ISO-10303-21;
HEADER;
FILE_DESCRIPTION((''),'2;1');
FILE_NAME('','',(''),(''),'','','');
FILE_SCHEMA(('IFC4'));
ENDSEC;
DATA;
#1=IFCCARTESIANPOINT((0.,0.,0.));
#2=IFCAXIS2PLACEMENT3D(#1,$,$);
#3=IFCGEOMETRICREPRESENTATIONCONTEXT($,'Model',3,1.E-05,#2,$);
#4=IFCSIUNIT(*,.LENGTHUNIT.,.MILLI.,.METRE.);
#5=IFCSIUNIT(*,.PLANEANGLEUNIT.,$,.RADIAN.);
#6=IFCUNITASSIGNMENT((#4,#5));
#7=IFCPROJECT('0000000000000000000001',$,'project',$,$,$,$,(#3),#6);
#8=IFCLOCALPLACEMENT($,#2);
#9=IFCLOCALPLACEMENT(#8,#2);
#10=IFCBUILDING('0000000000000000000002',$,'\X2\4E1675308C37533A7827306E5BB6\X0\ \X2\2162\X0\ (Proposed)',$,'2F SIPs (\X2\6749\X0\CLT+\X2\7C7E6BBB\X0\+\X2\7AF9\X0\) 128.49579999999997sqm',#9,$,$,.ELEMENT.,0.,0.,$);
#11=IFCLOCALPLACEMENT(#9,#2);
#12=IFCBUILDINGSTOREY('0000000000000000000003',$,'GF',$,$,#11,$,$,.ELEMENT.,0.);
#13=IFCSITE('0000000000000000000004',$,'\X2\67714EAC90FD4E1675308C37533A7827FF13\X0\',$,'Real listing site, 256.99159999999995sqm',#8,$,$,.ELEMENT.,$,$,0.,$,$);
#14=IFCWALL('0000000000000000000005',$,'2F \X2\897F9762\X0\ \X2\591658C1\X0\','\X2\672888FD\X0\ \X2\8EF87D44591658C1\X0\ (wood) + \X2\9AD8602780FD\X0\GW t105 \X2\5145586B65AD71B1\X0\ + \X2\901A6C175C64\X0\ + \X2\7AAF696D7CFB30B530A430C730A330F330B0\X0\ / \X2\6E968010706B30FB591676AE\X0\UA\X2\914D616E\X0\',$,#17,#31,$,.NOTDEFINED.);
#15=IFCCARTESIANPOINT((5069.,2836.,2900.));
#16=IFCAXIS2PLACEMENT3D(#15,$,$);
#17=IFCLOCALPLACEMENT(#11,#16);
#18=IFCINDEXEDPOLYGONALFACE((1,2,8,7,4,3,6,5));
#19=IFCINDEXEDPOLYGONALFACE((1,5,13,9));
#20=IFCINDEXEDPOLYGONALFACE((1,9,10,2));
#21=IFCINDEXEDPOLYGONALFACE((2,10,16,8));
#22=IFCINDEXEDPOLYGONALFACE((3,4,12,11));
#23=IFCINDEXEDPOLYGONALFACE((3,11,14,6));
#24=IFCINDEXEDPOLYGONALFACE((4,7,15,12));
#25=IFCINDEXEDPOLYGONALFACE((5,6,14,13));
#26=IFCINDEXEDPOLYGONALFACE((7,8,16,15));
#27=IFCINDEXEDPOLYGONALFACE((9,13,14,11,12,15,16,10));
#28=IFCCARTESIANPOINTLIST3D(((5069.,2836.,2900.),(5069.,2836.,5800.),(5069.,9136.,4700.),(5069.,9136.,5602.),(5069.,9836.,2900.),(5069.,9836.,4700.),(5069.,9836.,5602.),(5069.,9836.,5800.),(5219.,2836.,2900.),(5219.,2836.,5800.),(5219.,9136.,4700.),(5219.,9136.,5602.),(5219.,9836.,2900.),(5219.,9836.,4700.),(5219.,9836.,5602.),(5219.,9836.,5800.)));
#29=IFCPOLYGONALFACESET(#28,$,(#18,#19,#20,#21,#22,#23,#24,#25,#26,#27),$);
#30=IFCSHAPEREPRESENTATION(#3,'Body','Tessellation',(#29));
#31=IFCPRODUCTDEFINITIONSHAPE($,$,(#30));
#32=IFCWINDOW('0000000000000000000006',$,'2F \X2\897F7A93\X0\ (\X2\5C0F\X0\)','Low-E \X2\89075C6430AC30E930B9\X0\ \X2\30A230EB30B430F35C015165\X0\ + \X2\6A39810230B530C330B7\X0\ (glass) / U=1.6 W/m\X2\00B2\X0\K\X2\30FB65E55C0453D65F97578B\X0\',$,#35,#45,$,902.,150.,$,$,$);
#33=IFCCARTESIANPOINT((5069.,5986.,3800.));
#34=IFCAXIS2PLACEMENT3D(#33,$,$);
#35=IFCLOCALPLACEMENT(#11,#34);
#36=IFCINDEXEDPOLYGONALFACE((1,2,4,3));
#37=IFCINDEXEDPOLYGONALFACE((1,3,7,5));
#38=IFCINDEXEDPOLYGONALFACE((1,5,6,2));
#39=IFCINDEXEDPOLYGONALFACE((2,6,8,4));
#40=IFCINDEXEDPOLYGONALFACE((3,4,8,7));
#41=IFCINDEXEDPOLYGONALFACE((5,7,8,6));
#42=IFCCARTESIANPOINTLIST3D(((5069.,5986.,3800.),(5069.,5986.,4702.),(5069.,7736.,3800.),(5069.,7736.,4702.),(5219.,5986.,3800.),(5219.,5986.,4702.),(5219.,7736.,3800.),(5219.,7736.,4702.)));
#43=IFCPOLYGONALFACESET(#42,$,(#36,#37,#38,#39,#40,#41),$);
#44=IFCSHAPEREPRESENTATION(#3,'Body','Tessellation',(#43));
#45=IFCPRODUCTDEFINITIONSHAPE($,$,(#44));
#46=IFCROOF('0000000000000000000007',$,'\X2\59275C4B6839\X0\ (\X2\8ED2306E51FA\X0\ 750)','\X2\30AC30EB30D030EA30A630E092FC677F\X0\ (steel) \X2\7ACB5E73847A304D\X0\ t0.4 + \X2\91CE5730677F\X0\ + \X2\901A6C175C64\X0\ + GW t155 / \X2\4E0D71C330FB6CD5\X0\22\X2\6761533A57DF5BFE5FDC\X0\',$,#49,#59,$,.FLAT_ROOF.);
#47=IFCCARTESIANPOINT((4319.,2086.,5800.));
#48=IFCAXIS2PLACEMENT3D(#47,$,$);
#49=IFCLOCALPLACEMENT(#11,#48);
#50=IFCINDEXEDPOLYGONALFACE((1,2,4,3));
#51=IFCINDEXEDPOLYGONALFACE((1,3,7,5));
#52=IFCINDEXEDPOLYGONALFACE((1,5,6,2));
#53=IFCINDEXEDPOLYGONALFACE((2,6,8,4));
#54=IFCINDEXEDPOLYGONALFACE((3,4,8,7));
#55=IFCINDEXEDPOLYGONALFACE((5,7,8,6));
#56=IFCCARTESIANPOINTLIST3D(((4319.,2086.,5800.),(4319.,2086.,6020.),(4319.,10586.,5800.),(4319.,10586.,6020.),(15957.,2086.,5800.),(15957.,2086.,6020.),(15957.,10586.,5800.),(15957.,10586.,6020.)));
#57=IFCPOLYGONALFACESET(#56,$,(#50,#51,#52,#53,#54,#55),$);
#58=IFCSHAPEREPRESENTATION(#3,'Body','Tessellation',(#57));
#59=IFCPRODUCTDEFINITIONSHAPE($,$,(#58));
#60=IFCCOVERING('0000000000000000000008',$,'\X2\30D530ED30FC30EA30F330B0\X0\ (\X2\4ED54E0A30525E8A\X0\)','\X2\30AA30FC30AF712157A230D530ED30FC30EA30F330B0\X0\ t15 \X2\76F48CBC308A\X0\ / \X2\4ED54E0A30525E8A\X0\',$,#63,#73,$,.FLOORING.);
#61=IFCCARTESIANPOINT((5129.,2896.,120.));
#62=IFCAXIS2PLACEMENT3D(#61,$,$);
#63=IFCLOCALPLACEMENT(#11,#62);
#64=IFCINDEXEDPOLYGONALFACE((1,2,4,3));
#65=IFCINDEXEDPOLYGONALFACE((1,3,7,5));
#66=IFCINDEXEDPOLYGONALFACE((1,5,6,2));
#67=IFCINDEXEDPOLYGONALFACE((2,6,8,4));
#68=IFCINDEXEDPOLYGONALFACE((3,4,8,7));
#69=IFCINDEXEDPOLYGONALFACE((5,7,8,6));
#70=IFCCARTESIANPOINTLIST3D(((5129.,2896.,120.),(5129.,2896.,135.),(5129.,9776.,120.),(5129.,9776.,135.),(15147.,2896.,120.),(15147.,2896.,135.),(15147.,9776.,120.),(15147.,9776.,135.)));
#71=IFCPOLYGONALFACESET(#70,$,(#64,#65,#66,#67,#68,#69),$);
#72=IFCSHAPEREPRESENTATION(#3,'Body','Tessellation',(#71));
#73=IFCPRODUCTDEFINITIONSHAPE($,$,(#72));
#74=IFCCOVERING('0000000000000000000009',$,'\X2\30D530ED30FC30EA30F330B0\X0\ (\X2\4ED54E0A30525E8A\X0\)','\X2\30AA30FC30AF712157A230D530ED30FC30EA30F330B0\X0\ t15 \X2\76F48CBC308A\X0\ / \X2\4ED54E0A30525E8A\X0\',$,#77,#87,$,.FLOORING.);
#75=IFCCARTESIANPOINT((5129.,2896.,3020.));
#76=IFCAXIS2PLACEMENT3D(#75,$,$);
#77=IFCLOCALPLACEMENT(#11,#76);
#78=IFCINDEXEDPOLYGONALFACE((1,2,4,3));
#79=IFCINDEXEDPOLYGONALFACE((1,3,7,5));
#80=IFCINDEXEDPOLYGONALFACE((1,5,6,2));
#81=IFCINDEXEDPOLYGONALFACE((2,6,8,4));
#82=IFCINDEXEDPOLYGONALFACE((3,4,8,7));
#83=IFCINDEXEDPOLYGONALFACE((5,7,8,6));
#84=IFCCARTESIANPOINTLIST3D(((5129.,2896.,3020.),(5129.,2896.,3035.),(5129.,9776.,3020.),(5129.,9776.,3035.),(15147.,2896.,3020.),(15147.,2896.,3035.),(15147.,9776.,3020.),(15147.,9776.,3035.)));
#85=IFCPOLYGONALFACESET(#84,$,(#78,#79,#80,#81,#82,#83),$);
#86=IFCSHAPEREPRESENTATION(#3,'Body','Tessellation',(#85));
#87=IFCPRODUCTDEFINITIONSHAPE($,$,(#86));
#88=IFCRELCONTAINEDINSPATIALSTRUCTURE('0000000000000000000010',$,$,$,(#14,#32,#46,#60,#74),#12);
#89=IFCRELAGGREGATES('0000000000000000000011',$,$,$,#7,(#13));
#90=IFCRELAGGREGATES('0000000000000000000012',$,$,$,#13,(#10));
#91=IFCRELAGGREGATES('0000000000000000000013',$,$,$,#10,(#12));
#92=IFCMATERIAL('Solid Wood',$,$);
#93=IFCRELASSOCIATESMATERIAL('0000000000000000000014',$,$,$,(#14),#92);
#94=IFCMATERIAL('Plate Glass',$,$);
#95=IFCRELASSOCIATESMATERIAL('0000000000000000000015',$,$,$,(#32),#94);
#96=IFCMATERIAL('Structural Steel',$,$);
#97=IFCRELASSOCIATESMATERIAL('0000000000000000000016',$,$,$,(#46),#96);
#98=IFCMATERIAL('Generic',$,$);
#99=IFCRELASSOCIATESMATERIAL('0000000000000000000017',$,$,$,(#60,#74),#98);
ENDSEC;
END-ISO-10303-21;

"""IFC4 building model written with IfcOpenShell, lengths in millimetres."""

from ifc_helpers import new_model, si_unit, frame, frame_2d, origin, place, context, project, spatial, rectangle, extrude, material, element, fill, save


model = new_model("IFC4")

# Units and contexts
model_context = context("Model", 3, precision=1e-05, world=origin())
ifc_project = project(units=[si_unit("LENGTHUNIT", "METRE", prefix="MILLI"), si_unit("PLANEANGLEUNIT", "RADIAN")], contexts=[model_context])

# Site, building, storey
site_placement = place(None, origin())
site = spatial("IfcSite", under=ifc_project, at=site_placement, Name="東京都世田谷区砧３", ObjectType="Real listing site, 256.99159999999995sqm", CompositionType="ELEMENT", RefElevation=0.0)
building_placement = place(site_placement, origin())
building = spatial("IfcBuilding", under=site, at=building_placement, Name="世田谷区砧の家 Ⅲ (Proposed)", ObjectType="2F SIPs (杉CLT+籾殻+竹) 128.49579999999997sqm", CompositionType="ELEMENT", ElevationOfRefHeight=0.0, ElevationOfTerrain=0.0)
storey_placement = place(building_placement, origin())
storey = spatial("IfcBuildingStorey", under=building, at=storey_placement, Name="GF", CompositionType="ELEMENT", Elevation=0.0)

# Shared definitions
ifc_material_1 = material(Name="Solid Wood")

# Shared definitions
ifc_material_2 = material(Name="Plate Glass")

# Wall, opening, window
wall_1_placement = place(storey_placement, frame((5069.0, 2836.0, 2900.0)))
wall_1 = element("IfcWall", 1, at=wall_1_placement, inside=storey, material=ifc_material_1, Name="2F 西面 外壁", Description="木製 軸組外壁 (wood) + 高性能GW t105 充填断熱 + 通気層 + 窯業系サイディング / 準耐火・外皮UA配慮", PredefinedType="NOTDEFINED", context=model_context, shape_type="SweptSolid", body=[
    extrude(rectangle(XDim=150.0, YDim=7000.0, at=frame_2d((75.0, 3500.0))), frame((5069.0, 2836.0, 2900.0)), (0.0, 0.0, 1.0), 2900.0),
])
opening_1_placement = place(storey_placement, frame((5069.0, 5986.0, 3800.0)))
opening_1 = element("IfcOpeningElement", 2, at=opening_1_placement, cuts=wall_1, PredefinedType="NOTDEFINED", context=model_context, shape_type="SweptSolid", body=[
    extrude(rectangle(XDim=150.0, YDim=1750.0, at=frame_2d((75.0, 875.0))), frame((5069.0, 5986.0, 3800.0)), (0.0, 0.0, 1.0), 902.0),
])
window_1_placement = place(storey_placement, frame((5069.0, 5986.0, 3800.0)))
window_1 = element("IfcWindow", 3, at=window_1_placement, inside=storey, material=ifc_material_2, Name="2F 西窓 (小)", Description="Low-E 複層ガラス アルゴン封入 + 樹脂サッシ (glass) / U=1.6 W/m²K・日射取得型", OverallHeight=902.0, OverallWidth=150.0, context=model_context, shape_type="SweptSolid", body=[
    extrude(rectangle(XDim=150.0, YDim=1750.0, at=frame_2d((75.0, 875.0))), frame((5069.0, 5986.0, 3800.0)), (0.0, 0.0, 1.0), 902.0),
])
fill(opening_1, window_1)

# Roof
ifc_material_3 = material(Name="Structural Steel")
roof_placement = place(storey_placement, frame((4319.0, 2086.0, 5800.0)))
element("IfcRoof", 4, at=roof_placement, inside=storey, material=ifc_material_3, Name="大屋根 (軒の出 750)", Description="ガルバリウム鋼板 (steel) 立平葺き t0.4 + 野地板 + 通気層 + GW t155 / 不燃・法22条区域対応", PredefinedType="FLAT_ROOF", context=model_context, shape_type="SweptSolid", body=[
    extrude(rectangle(XDim=11638.0, YDim=8500.0, at=frame_2d((5819.0, 4250.0))), frame((4319.0, 2086.0, 5800.0)), (0.0, 0.0, 1.0), 220.0),
])

# Coverings
ifc_material_4 = material(Name="Generic")
covering_1_placement = place(storey_placement, frame((5129.0, 2896.0, 120.0)))
element("IfcCovering", 5, at=covering_1_placement, inside=storey, material=ifc_material_4, Name="フローリング (仕上げ床)", Description="オーク無垢フローリング t15 直貼り / 仕上げ床", PredefinedType="FLOORING", context=model_context, shape_type="SweptSolid", body=[
    extrude(rectangle(XDim=10018.0, YDim=6880.0, at=frame_2d((5009.0, 3440.0))), frame((5129.0, 2896.0, 120.0)), (0.0, 0.0, 1.0), 15.0),
])
covering_2_placement = place(storey_placement, frame((5129.0, 2896.0, 3020.0)))
element("IfcCovering", 6, at=covering_2_placement, inside=storey, material=ifc_material_4, Name="フローリング (仕上げ床)", Description="オーク無垢フローリング t15 直貼り / 仕上げ床", PredefinedType="FLOORING", context=model_context, shape_type="SweptSolid", body=[
    extrude(rectangle(XDim=10018.0, YDim=6880.0, at=frame_2d((5009.0, 3440.0))), frame((5129.0, 2896.0, 3020.0)), (0.0, 0.0, 1.0), 15.0),
])

save(model, "model.ifc")
